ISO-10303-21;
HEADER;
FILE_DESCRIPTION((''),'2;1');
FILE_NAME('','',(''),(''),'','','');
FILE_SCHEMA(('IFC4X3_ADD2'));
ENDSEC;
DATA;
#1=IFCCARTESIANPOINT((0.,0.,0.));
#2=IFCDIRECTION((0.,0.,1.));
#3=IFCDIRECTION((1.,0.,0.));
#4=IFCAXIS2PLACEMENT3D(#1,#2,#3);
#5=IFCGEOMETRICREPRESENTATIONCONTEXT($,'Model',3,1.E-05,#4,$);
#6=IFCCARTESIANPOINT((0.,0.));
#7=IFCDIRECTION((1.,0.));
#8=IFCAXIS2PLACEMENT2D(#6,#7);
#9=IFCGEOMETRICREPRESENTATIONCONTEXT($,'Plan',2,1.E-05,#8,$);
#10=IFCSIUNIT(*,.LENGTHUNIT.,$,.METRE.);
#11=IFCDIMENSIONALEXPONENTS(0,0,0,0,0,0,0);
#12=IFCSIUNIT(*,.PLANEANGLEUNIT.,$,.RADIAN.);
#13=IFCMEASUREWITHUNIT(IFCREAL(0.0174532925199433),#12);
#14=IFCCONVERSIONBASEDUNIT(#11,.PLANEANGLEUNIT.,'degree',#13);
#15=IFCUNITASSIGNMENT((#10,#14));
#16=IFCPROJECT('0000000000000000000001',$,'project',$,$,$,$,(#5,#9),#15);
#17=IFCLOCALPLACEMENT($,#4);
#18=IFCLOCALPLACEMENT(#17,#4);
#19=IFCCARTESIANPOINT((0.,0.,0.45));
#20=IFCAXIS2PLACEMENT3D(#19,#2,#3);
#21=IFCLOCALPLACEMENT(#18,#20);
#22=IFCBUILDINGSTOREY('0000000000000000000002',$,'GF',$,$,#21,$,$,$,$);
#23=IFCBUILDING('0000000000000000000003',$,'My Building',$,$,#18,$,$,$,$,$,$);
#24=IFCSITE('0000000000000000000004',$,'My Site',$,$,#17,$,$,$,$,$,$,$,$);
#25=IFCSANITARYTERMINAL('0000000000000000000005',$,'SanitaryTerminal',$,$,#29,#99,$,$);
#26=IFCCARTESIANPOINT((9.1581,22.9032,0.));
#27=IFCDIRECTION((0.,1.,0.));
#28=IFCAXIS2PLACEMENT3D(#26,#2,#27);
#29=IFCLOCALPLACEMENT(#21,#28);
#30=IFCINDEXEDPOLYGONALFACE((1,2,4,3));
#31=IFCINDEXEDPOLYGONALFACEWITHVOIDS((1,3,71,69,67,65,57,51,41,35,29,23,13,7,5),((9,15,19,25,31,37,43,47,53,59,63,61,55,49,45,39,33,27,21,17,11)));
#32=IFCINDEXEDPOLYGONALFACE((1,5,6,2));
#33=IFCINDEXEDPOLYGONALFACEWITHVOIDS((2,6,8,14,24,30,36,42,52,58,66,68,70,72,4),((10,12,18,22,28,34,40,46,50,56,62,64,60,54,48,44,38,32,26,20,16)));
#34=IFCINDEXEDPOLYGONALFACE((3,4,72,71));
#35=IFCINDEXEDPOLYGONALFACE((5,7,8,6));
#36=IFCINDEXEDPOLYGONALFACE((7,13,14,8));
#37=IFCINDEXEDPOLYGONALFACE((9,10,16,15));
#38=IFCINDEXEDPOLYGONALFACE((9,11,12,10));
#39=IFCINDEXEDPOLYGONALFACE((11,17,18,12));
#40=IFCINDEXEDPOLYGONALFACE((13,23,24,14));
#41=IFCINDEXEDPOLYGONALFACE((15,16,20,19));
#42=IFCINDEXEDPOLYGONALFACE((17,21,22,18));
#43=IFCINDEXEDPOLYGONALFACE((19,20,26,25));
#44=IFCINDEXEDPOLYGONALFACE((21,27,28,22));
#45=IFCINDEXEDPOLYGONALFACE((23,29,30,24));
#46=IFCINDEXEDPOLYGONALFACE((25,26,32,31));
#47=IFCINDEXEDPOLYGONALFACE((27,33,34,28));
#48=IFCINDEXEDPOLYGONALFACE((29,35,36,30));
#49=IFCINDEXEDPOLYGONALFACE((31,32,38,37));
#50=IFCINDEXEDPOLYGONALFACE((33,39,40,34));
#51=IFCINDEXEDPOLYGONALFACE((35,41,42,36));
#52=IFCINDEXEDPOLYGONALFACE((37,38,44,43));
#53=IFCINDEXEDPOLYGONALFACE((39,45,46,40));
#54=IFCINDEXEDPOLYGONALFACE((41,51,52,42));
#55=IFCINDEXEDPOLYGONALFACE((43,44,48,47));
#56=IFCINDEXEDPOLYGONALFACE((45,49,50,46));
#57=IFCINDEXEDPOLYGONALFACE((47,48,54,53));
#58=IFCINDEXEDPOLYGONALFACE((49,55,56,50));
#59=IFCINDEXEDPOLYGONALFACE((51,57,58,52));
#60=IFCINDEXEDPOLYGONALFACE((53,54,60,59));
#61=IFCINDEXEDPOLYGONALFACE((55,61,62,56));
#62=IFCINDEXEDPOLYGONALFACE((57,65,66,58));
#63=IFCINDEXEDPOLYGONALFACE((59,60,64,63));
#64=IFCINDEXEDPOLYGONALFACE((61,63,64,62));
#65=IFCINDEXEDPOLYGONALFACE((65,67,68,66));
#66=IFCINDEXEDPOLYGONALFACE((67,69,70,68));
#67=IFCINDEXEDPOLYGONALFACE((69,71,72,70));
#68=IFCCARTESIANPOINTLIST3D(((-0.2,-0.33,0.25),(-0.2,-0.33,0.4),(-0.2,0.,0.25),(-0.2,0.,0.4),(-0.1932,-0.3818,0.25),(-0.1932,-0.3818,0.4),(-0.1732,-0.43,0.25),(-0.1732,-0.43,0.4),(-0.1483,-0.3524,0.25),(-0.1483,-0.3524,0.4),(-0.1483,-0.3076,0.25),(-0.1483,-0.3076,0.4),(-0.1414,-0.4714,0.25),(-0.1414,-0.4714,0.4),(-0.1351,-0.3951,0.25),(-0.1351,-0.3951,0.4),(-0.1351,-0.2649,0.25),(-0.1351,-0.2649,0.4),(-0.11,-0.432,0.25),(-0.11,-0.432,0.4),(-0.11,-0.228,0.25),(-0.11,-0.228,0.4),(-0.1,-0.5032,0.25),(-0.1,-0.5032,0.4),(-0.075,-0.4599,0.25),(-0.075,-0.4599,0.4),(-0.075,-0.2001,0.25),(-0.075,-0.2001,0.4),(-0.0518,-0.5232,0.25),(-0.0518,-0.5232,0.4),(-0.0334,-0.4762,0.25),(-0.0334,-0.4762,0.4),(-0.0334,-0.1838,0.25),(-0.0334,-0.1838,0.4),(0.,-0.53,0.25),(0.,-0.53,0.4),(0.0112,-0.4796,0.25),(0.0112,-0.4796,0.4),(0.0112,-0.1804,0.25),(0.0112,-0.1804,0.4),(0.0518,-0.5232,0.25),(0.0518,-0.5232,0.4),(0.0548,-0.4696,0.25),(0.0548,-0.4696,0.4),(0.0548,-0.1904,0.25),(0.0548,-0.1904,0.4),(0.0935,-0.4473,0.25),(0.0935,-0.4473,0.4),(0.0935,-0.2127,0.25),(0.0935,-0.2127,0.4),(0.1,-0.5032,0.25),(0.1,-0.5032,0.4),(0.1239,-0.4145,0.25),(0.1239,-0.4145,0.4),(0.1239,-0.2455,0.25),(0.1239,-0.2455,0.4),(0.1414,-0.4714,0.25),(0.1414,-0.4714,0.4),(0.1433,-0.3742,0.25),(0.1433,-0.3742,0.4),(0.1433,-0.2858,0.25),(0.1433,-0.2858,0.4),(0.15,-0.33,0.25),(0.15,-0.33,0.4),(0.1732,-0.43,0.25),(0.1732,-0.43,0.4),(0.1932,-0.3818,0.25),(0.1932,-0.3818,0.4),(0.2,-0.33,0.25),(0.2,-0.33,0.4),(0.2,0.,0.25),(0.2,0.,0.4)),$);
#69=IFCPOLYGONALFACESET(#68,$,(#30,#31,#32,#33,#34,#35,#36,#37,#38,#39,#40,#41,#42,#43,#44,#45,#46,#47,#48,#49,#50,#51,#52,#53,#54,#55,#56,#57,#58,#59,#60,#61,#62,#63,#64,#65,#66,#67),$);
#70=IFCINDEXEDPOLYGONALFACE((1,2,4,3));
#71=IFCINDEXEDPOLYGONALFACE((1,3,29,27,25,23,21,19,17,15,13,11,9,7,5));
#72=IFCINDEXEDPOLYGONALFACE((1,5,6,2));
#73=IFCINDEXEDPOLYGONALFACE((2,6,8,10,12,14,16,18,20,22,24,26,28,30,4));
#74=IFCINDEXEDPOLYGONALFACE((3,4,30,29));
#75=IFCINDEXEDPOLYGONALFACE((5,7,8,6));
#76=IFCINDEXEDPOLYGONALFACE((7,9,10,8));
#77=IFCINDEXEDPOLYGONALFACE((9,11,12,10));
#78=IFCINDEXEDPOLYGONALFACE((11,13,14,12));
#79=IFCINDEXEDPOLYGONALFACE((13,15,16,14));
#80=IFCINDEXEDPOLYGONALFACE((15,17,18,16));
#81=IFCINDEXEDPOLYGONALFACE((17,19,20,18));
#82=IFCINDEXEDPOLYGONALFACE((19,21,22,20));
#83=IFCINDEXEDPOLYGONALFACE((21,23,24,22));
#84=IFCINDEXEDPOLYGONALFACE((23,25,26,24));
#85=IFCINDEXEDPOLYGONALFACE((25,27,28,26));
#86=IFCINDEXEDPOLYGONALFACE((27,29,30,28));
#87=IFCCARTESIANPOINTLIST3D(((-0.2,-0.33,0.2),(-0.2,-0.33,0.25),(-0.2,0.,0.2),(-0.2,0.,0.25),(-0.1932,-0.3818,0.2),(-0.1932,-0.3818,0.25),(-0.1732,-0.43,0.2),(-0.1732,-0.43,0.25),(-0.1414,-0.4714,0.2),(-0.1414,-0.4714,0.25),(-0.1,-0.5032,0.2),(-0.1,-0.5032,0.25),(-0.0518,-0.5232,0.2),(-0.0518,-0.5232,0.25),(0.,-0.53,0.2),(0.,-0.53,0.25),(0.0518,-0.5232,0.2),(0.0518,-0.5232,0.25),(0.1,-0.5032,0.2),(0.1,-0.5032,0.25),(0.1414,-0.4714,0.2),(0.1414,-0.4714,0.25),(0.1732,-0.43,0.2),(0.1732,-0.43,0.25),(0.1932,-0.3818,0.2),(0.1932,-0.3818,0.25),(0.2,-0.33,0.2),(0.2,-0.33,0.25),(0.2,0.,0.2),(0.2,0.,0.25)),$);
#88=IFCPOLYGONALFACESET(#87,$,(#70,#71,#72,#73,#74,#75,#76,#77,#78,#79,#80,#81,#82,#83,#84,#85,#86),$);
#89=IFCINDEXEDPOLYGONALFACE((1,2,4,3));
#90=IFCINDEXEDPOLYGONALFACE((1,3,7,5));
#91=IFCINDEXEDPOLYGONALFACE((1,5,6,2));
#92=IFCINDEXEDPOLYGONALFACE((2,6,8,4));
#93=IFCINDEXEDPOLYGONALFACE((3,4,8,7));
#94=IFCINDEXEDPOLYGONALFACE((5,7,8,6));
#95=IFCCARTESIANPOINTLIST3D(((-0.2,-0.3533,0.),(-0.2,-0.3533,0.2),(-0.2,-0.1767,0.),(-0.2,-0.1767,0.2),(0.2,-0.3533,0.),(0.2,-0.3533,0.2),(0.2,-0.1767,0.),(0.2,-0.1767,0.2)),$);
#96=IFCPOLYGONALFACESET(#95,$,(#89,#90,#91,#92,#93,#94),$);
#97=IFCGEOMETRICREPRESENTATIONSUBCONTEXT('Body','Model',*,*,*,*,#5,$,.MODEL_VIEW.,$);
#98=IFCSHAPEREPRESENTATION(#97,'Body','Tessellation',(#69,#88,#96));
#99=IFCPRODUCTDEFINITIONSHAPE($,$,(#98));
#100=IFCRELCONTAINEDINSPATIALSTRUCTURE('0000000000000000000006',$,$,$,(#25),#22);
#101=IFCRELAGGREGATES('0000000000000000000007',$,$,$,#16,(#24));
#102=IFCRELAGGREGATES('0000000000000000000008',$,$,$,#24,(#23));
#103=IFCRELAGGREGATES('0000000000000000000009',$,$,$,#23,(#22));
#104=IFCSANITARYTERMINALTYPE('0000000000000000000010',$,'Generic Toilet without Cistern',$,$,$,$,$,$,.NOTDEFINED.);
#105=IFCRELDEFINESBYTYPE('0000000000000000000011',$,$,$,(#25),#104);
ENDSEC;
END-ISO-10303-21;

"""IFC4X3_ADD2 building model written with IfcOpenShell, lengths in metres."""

from ifc_helpers import new_model, entity, si_unit, converted_unit, frame, frame_2d, origin_with_axes, origin_2d_with_axis, place, context, subcontext, project, spatial, line, arc, indexed_curve, circle_curve, outline, extrude, shape, source, transform, mapped, type_object, type_shapes, element, save


model = new_model("IFC4X3_ADD2")

# Units and contexts
model_context = context("Model", 3, precision=1e-05, world=origin_with_axes())
plan_context = context("Plan", 2, precision=1e-05, world=origin_2d_with_axis())
body_context_1 = subcontext(model_context, "Body", "Model", "MODEL_VIEW")
body_context_2 = subcontext(plan_context, "Body", "Plan", "PLAN_VIEW")
ifc_project = project(units=[si_unit("LENGTHUNIT", "METRE"), converted_unit("PLANEANGLEUNIT", "degree", entity("IfcReal", 0.0174532925199433), si_unit("PLANEANGLEUNIT", "RADIAN"), dimensions=[0, 0, 0, 0, 0, 0, 0])], contexts=[model_context, plan_context])

# Site, building, storey
site_placement = place(None, origin_with_axes())
site = spatial("IfcSite", under=ifc_project, at=site_placement, Name="My Site")
building_placement = place(site_placement, origin_with_axes())
building = spatial("IfcBuilding", under=site, at=building_placement, Name="My Building")
storey_placement = place(building_placement, frame((0.0, 0.0, 0.45), z_axis=(0.0, 0.0, 1.0), x_axis=(1.0, 0.0, 0.0)))
storey = spatial("IfcBuildingStorey", under=building, at=storey_placement, Name="GF")

# Sanitary terminal
sanitary_terminal_type_1 = type_object("IfcSanitaryTerminalType", Name="Generic Toilet without Cistern", PredefinedType="NOTDEFINED")
shared_shape_1 = source(origin_with_axes(), body_context_1, "Body", "SweptSolid", [
    extrude(outline(indexed_curve([(-0.2, 0.0), (0.2, 0.0), (0.2, -0.33), (0.1414, -0.4714), (0.0, -0.53), (-0.1414, -0.4714), (-0.2, -0.33)], segments=[line(1, 2), line(2, 3), arc(3, 4, 5), arc(5, 6, 7), line(7, 1)]), holes=[circle_curve(frame_2d((0.0, -0.33)), 0.15)]), frame((0.0, 0.0, 0.25), z_axis=(0.0, 0.0, 1.0), x_axis=(1.0, 0.0, 0.0)), (0.0, 0.0, 1.0), 0.15),
    extrude(outline(indexed_curve([(-0.2, 0.0), (0.2, 0.0), (0.2, -0.33), (0.1414, -0.4714), (0.0, -0.53), (-0.1414, -0.4714), (-0.2, -0.33)], segments=[line(1, 2), line(2, 3), arc(3, 4, 5), arc(5, 6, 7), line(7, 1)])), frame((0.0, 0.0, 0.2), z_axis=(0.0, 0.0, 1.0), x_axis=(1.0, 0.0, 0.0)), (0.0, 0.0, 1.0), 0.05),
    extrude(outline(indexed_curve([(-0.2, -0.1767), (0.2, -0.1767), (0.2, -0.3533), (-0.2, -0.3533)], segments=[line(1, 2, 3, 4, 1)])), origin_with_axes(), (0.0, 0.0, 1.0), 0.2),
])
shared_shape_2 = source(origin_with_axes(), body_context_2, "Body", "Annotation2D", [
    entity("IfcGeometricCurveSet", [entity("IfcIndexedPolyCurve", entity("IfcCartesianPointList2D", [[-0.1068, -0.124], [-0.0957, -0.1129], [-0.0804, -0.1088], [0.0804, -0.1088], [0.0957, -0.1129], [0.1068, -0.124], [0.1109, -0.1393], [0.1109, -0.3476], [0.1025, -0.3926], [0.0784, -0.4308], [0.0424, -0.4563], [0.0, -0.4652], [-0.0424, -0.4563], [-0.0784, -0.4308], [-0.1025, -0.3926], [-0.1109, -0.3476], [-0.1109, -0.1393]]), [entity("IfcLineIndex", [1, 2, 3, 4, 5, 6, 7, 8, 9, 10, 11, 12, 13, 14, 15, 16, 17, 1])]), entity("IfcIndexedPolyCurve", entity("IfcCartesianPointList2D", [[-0.1962, -0.2314], [-0.1848, -0.301], [-0.1764, -0.3339], [-0.1663, -0.3651], [-0.1546, -0.3944], [-0.1414, -0.4213], [-0.1269, -0.4458], [-0.1111, -0.4675], [-0.0943, -0.4862], [-0.0765, -0.5018], [-0.0581, -0.514], [-0.039, -0.5229], [-0.0196, -0.5282], [0.0, -0.53], [0.0196, -0.5282], [0.039, -0.5229], [0.0581, -0.514], [0.0765, -0.5018], [0.0943, -0.4862], [0.1111, -0.4675], [0.1269, -0.4458], [0.1414, -0.4213], [0.1546, -0.3944], [0.1663, -0.3651], [0.1764, -0.3339], [0.1848, -0.301], [0.1962, -0.2314], [0.2, -0.159], [0.1872, 0.0], [-0.1872, 0.0], [-0.2, -0.159]]), [entity("IfcLineIndex", [1, 2, 3, 4, 5, 6, 7, 8, 9, 10, 11, 12, 13, 14, 15, 16, 17, 18, 19, 20, 21, 22, 23, 24, 25, 26, 27, 28, 29, 30, 31, 1])])]),
])
type_shapes(sanitary_terminal_type_1, [shared_shape_1, shared_shape_2])
for number, where, z_axis, x_axis, name in (
    (1, (9.1581, 22.9032, 0.0), (0.0, 0.0, 1.0), (0.0, 1.0, 0.0), "SanitaryTerminal"),
):
    element("IfcSanitaryTerminal", number, at=place(storey_placement, frame(where, z_axis=z_axis, x_axis=x_axis)), inside=storey, type_object=sanitary_terminal_type_1, Name=name, shapes=[
        shape(body_context_1, "Body", "MappedRepresentation", [mapped(shared_shape_1, transform((0.0, 0.0, 0.0), x_axis=(1.0, 0.0, 0.0), y_axis=(0.0, 1.0, 0.0), z_axis=(0.0, 0.0, 1.0), scale=1.0))]),
        shape(body_context_2, "Body", "MappedRepresentation", [mapped(shared_shape_2, transform((0.0, 0.0, 0.0), x_axis=(1.0, 0.0, 0.0), y_axis=(0.0, 1.0, 0.0), z_axis=(0.0, 0.0, 1.0), scale=1.0))]),
    ])

save(model, "model.ifc")
